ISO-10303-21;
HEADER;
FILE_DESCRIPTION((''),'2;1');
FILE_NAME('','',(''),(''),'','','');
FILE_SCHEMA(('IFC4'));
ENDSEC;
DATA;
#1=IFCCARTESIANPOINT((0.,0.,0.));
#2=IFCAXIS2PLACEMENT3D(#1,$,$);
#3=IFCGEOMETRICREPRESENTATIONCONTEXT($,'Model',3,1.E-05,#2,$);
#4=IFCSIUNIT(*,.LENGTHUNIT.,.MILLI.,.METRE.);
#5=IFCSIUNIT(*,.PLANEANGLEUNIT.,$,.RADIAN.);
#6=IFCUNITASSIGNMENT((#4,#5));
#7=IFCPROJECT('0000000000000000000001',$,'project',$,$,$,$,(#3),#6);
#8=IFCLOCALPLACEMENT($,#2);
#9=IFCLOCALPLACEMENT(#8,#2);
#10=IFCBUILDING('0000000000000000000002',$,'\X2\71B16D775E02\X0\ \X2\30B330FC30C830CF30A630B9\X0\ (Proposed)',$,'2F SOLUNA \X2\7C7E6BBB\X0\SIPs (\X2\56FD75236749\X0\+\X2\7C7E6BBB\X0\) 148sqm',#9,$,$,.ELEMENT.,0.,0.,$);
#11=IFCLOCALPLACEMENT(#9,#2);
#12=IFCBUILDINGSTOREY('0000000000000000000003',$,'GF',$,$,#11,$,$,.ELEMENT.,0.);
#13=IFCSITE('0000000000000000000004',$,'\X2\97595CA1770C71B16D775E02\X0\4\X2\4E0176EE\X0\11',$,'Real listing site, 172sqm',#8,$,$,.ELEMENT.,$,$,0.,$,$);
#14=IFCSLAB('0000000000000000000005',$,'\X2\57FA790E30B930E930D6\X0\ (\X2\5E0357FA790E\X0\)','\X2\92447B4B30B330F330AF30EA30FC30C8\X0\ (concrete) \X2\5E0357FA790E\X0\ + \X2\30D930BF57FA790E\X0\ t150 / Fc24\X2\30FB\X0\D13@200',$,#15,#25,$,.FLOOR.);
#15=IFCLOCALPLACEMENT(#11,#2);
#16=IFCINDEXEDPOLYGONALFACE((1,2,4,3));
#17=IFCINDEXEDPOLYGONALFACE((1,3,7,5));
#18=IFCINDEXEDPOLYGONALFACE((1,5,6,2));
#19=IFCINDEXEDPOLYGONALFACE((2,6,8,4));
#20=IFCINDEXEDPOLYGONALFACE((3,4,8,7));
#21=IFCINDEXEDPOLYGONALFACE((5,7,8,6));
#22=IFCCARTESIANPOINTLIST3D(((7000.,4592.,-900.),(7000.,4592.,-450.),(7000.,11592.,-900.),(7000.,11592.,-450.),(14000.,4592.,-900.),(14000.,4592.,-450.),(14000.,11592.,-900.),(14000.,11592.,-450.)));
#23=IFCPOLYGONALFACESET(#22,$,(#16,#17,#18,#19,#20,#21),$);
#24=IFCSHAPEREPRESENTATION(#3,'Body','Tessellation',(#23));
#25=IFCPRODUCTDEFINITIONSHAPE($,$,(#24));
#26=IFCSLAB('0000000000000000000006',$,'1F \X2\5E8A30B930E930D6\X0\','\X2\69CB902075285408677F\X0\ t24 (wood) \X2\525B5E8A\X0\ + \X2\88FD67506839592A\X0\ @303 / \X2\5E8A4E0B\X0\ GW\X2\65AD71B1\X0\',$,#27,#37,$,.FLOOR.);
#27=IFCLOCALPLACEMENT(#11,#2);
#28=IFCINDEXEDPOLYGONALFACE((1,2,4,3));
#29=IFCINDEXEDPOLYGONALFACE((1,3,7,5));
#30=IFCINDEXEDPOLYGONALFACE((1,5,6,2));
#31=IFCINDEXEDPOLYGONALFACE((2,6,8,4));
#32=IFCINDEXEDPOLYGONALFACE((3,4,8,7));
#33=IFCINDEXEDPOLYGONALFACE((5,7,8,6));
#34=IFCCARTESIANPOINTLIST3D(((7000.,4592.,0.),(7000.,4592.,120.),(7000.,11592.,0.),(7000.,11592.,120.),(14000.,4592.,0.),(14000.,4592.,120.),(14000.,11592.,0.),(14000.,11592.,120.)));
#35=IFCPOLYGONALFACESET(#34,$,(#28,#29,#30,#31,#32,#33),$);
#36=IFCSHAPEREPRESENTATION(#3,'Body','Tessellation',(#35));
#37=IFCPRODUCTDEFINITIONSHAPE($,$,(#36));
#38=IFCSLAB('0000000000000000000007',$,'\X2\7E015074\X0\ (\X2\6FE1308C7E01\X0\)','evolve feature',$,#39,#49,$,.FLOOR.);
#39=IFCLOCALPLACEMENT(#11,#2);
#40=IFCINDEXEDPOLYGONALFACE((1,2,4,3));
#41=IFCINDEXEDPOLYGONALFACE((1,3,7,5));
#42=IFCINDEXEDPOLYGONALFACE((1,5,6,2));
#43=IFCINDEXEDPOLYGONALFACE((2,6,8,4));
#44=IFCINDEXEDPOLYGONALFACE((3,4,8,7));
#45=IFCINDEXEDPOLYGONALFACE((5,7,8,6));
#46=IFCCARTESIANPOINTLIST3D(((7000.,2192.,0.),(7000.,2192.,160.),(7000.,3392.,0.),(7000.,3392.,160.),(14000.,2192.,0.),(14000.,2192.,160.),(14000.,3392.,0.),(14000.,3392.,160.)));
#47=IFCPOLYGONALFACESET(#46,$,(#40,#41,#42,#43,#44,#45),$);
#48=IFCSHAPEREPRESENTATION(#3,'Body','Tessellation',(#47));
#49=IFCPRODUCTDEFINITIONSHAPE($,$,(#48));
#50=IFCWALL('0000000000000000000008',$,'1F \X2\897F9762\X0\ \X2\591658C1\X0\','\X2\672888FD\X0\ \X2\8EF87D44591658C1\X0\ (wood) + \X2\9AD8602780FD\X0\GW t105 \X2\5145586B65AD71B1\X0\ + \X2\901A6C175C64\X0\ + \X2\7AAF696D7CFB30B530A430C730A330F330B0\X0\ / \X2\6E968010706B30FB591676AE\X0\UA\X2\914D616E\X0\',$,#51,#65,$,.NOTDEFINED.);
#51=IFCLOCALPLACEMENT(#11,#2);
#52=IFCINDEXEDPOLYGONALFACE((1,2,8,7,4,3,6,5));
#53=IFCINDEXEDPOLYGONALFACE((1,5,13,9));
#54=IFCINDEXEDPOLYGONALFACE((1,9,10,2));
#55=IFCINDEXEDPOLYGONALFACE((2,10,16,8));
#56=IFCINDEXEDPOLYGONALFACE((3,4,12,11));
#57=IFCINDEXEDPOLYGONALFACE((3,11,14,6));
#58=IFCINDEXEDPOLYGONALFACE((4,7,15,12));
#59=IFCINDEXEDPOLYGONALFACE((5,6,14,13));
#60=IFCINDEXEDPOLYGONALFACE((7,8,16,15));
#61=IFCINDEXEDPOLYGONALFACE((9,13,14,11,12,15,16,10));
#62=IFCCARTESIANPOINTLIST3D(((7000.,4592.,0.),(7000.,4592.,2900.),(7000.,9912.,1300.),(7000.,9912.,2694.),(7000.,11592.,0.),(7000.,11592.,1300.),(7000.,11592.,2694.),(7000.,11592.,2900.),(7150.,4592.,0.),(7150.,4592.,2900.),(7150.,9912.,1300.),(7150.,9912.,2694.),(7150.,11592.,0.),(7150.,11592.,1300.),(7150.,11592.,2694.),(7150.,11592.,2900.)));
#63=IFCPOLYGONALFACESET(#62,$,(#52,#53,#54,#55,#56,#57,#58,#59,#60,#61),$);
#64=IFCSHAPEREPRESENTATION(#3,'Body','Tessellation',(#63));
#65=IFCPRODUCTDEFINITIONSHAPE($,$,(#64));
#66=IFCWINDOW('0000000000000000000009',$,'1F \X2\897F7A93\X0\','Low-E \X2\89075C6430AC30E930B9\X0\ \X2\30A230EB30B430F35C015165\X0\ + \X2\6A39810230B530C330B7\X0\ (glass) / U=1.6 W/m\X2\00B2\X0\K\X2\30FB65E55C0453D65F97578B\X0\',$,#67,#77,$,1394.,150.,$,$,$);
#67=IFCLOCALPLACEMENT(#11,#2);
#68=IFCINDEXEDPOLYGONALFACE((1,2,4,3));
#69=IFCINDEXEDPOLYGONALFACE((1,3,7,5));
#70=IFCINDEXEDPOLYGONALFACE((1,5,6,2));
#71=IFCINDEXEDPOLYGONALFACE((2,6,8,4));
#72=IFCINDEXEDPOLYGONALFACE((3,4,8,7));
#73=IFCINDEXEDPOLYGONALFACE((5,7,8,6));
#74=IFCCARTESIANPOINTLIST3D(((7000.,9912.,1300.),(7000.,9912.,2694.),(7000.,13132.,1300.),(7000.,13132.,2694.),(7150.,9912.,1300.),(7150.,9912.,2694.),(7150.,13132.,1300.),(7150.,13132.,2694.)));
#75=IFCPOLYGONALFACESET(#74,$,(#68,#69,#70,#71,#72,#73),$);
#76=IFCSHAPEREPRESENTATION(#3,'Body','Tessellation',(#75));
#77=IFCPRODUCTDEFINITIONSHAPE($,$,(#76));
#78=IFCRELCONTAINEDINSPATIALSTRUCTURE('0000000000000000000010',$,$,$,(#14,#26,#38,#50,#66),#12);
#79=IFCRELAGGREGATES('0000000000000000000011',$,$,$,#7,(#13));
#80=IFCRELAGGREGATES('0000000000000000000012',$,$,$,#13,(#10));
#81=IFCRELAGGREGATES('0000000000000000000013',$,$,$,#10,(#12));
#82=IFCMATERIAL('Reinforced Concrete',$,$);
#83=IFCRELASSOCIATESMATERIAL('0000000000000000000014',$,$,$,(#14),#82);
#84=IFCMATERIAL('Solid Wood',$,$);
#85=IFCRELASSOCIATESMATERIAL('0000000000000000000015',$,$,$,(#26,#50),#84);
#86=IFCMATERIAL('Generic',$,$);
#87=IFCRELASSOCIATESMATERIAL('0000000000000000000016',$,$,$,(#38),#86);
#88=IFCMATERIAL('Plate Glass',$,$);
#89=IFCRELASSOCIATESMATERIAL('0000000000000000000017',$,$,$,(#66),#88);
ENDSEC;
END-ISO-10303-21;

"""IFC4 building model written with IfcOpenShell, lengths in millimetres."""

from ifc_helpers import new_model, si_unit, frame, frame_2d, origin, place, context, project, spatial, rectangle, extrude, material, element, fill, save


model = new_model("IFC4")

# Units and contexts
model_context = context("Model", 3, precision=1e-05, world=origin())
ifc_project = project(units=[si_unit("LENGTHUNIT", "METRE", prefix="MILLI"), si_unit("PLANEANGLEUNIT", "RADIAN")], contexts=[model_context])

# Site, building, storey
site_placement = place(None, origin())
site = spatial("IfcSite", under=ifc_project, at=site_placement, Name="静岡県熱海市4丁目11", ObjectType="Real listing site, 172sqm", CompositionType="ELEMENT", RefElevation=0.0)
building_placement = place(site_placement, origin())
building = spatial("IfcBuilding", under=site, at=building_placement, Name="熱海市 コートハウス (Proposed)", ObjectType="2F SOLUNA 籾殻SIPs (国産杉+籾殻) 148sqm", CompositionType="ELEMENT", ElevationOfRefHeight=0.0, ElevationOfTerrain=0.0)
storey_placement = place(building_placement, origin())
storey = spatial("IfcBuildingStorey", under=building, at=storey_placement, Name="GF", CompositionType="ELEMENT", Elevation=0.0)

# Slabs
ifc_material_1 = material(Name="Reinforced Concrete")
slab_1_placement = place(storey_placement, frame((3500.0, 2296.0, -450.0)))
element("IfcSlab", 1, at=slab_1_placement, inside=storey, material=ifc_material_1, Name="基礎スラブ (布基礎)", Description="鉄筋コンクリート (concrete) 布基礎 + ベタ基礎 t150 / Fc24・D13@200", PredefinedType="FLOOR", context=model_context, shape_type="SweptSolid", body=[
    extrude(rectangle(XDim=7000.0, YDim=7000.0, at=frame_2d((3500.0, 3500.0))), frame((3500.0, 2296.0, -450.0)), (0.0, 0.0, 1.0), 450.0),
])
ifc_material_2 = material(Name="Solid Wood")
slab_2_placement = place(storey_placement, frame((3500.0, 2296.0, 0.0)))
element("IfcSlab", 2, at=slab_2_placement, inside=storey, material=ifc_material_2, Name="1F 床スラブ", Description="構造用合板 t24 (wood) 剛床 + 製材根太 @303 / 床下 GW断熱", PredefinedType="FLOOR", context=model_context, shape_type="SweptSolid", body=[
    extrude(rectangle(XDim=7000.0, YDim=7000.0, at=frame_2d((3500.0, 3500.0))), frame((3500.0, 2296.0, 0.0)), (0.0, 0.0, 1.0), 120.0),
])
ifc_material_3 = material(Name="Generic")
slab_3_placement = place(storey_placement, frame((3500.0, 1096.0, 0.0)))
element("IfcSlab", 3, at=slab_3_placement, inside=storey, material=ifc_material_3, Name="縁側 (濡れ縁)", Description="evolve feature", PredefinedType="FLOOR", context=model_context, shape_type="SweptSolid", body=[
    extrude(rectangle(XDim=7000.0, YDim=1200.0, at=frame_2d((3500.0, 600.0))), frame((3500.0, 1096.0, 0.0)), (0.0, 0.0, 1.0), 160.0),
])

# Shared definitions
ifc_material_4 = material(Name="Plate Glass")

# Wall, opening, window
wall_1_placement = place(storey_placement, frame((3500.0, 2296.0, 0.0)))
wall_1 = element("IfcWall", 4, at=wall_1_placement, inside=storey, material=ifc_material_2, Name="1F 西面 外壁", Description="木製 軸組外壁 (wood) + 高性能GW t105 充填断熱 + 通気層 + 窯業系サイディング / 準耐火・外皮UA配慮", PredefinedType="NOTDEFINED", context=model_context, shape_type="SweptSolid", body=[
    extrude(rectangle(XDim=150.0, YDim=7000.0, at=frame_2d((75.0, 3500.0))), frame((3500.0, 2296.0, 0.0)), (0.0, 0.0, 1.0), 2900.0),
])
opening_1_placement = place(storey_placement, frame((3500.0, 4956.0, 650.0)))
opening_1 = element("IfcOpeningElement", 5, at=opening_1_placement, cuts=wall_1, PredefinedType="NOTDEFINED", context=model_context, shape_type="SweptSolid", body=[
    extrude(rectangle(XDim=150.0, YDim=3220.0, at=frame_2d((75.0, 1610.0))), frame((3500.0, 4956.0, 650.0)), (0.0, 0.0, 1.0), 1394.0),
])
window_1_placement = place(storey_placement, frame((3500.0, 4956.0, 650.0)))
window_1 = element("IfcWindow", 6, at=window_1_placement, inside=storey, material=ifc_material_4, Name="1F 西窓", Description="Low-E 複層ガラス アルゴン封入 + 樹脂サッシ (glass) / U=1.6 W/m²K・日射取得型", OverallHeight=1394.0, OverallWidth=150.0, context=model_context, shape_type="SweptSolid", body=[
    extrude(rectangle(XDim=150.0, YDim=3220.0, at=frame_2d((75.0, 1610.0))), frame((3500.0, 4956.0, 650.0)), (0.0, 0.0, 1.0), 1394.0),
])
fill(opening_1, window_1)

save(model, "model.ifc")
